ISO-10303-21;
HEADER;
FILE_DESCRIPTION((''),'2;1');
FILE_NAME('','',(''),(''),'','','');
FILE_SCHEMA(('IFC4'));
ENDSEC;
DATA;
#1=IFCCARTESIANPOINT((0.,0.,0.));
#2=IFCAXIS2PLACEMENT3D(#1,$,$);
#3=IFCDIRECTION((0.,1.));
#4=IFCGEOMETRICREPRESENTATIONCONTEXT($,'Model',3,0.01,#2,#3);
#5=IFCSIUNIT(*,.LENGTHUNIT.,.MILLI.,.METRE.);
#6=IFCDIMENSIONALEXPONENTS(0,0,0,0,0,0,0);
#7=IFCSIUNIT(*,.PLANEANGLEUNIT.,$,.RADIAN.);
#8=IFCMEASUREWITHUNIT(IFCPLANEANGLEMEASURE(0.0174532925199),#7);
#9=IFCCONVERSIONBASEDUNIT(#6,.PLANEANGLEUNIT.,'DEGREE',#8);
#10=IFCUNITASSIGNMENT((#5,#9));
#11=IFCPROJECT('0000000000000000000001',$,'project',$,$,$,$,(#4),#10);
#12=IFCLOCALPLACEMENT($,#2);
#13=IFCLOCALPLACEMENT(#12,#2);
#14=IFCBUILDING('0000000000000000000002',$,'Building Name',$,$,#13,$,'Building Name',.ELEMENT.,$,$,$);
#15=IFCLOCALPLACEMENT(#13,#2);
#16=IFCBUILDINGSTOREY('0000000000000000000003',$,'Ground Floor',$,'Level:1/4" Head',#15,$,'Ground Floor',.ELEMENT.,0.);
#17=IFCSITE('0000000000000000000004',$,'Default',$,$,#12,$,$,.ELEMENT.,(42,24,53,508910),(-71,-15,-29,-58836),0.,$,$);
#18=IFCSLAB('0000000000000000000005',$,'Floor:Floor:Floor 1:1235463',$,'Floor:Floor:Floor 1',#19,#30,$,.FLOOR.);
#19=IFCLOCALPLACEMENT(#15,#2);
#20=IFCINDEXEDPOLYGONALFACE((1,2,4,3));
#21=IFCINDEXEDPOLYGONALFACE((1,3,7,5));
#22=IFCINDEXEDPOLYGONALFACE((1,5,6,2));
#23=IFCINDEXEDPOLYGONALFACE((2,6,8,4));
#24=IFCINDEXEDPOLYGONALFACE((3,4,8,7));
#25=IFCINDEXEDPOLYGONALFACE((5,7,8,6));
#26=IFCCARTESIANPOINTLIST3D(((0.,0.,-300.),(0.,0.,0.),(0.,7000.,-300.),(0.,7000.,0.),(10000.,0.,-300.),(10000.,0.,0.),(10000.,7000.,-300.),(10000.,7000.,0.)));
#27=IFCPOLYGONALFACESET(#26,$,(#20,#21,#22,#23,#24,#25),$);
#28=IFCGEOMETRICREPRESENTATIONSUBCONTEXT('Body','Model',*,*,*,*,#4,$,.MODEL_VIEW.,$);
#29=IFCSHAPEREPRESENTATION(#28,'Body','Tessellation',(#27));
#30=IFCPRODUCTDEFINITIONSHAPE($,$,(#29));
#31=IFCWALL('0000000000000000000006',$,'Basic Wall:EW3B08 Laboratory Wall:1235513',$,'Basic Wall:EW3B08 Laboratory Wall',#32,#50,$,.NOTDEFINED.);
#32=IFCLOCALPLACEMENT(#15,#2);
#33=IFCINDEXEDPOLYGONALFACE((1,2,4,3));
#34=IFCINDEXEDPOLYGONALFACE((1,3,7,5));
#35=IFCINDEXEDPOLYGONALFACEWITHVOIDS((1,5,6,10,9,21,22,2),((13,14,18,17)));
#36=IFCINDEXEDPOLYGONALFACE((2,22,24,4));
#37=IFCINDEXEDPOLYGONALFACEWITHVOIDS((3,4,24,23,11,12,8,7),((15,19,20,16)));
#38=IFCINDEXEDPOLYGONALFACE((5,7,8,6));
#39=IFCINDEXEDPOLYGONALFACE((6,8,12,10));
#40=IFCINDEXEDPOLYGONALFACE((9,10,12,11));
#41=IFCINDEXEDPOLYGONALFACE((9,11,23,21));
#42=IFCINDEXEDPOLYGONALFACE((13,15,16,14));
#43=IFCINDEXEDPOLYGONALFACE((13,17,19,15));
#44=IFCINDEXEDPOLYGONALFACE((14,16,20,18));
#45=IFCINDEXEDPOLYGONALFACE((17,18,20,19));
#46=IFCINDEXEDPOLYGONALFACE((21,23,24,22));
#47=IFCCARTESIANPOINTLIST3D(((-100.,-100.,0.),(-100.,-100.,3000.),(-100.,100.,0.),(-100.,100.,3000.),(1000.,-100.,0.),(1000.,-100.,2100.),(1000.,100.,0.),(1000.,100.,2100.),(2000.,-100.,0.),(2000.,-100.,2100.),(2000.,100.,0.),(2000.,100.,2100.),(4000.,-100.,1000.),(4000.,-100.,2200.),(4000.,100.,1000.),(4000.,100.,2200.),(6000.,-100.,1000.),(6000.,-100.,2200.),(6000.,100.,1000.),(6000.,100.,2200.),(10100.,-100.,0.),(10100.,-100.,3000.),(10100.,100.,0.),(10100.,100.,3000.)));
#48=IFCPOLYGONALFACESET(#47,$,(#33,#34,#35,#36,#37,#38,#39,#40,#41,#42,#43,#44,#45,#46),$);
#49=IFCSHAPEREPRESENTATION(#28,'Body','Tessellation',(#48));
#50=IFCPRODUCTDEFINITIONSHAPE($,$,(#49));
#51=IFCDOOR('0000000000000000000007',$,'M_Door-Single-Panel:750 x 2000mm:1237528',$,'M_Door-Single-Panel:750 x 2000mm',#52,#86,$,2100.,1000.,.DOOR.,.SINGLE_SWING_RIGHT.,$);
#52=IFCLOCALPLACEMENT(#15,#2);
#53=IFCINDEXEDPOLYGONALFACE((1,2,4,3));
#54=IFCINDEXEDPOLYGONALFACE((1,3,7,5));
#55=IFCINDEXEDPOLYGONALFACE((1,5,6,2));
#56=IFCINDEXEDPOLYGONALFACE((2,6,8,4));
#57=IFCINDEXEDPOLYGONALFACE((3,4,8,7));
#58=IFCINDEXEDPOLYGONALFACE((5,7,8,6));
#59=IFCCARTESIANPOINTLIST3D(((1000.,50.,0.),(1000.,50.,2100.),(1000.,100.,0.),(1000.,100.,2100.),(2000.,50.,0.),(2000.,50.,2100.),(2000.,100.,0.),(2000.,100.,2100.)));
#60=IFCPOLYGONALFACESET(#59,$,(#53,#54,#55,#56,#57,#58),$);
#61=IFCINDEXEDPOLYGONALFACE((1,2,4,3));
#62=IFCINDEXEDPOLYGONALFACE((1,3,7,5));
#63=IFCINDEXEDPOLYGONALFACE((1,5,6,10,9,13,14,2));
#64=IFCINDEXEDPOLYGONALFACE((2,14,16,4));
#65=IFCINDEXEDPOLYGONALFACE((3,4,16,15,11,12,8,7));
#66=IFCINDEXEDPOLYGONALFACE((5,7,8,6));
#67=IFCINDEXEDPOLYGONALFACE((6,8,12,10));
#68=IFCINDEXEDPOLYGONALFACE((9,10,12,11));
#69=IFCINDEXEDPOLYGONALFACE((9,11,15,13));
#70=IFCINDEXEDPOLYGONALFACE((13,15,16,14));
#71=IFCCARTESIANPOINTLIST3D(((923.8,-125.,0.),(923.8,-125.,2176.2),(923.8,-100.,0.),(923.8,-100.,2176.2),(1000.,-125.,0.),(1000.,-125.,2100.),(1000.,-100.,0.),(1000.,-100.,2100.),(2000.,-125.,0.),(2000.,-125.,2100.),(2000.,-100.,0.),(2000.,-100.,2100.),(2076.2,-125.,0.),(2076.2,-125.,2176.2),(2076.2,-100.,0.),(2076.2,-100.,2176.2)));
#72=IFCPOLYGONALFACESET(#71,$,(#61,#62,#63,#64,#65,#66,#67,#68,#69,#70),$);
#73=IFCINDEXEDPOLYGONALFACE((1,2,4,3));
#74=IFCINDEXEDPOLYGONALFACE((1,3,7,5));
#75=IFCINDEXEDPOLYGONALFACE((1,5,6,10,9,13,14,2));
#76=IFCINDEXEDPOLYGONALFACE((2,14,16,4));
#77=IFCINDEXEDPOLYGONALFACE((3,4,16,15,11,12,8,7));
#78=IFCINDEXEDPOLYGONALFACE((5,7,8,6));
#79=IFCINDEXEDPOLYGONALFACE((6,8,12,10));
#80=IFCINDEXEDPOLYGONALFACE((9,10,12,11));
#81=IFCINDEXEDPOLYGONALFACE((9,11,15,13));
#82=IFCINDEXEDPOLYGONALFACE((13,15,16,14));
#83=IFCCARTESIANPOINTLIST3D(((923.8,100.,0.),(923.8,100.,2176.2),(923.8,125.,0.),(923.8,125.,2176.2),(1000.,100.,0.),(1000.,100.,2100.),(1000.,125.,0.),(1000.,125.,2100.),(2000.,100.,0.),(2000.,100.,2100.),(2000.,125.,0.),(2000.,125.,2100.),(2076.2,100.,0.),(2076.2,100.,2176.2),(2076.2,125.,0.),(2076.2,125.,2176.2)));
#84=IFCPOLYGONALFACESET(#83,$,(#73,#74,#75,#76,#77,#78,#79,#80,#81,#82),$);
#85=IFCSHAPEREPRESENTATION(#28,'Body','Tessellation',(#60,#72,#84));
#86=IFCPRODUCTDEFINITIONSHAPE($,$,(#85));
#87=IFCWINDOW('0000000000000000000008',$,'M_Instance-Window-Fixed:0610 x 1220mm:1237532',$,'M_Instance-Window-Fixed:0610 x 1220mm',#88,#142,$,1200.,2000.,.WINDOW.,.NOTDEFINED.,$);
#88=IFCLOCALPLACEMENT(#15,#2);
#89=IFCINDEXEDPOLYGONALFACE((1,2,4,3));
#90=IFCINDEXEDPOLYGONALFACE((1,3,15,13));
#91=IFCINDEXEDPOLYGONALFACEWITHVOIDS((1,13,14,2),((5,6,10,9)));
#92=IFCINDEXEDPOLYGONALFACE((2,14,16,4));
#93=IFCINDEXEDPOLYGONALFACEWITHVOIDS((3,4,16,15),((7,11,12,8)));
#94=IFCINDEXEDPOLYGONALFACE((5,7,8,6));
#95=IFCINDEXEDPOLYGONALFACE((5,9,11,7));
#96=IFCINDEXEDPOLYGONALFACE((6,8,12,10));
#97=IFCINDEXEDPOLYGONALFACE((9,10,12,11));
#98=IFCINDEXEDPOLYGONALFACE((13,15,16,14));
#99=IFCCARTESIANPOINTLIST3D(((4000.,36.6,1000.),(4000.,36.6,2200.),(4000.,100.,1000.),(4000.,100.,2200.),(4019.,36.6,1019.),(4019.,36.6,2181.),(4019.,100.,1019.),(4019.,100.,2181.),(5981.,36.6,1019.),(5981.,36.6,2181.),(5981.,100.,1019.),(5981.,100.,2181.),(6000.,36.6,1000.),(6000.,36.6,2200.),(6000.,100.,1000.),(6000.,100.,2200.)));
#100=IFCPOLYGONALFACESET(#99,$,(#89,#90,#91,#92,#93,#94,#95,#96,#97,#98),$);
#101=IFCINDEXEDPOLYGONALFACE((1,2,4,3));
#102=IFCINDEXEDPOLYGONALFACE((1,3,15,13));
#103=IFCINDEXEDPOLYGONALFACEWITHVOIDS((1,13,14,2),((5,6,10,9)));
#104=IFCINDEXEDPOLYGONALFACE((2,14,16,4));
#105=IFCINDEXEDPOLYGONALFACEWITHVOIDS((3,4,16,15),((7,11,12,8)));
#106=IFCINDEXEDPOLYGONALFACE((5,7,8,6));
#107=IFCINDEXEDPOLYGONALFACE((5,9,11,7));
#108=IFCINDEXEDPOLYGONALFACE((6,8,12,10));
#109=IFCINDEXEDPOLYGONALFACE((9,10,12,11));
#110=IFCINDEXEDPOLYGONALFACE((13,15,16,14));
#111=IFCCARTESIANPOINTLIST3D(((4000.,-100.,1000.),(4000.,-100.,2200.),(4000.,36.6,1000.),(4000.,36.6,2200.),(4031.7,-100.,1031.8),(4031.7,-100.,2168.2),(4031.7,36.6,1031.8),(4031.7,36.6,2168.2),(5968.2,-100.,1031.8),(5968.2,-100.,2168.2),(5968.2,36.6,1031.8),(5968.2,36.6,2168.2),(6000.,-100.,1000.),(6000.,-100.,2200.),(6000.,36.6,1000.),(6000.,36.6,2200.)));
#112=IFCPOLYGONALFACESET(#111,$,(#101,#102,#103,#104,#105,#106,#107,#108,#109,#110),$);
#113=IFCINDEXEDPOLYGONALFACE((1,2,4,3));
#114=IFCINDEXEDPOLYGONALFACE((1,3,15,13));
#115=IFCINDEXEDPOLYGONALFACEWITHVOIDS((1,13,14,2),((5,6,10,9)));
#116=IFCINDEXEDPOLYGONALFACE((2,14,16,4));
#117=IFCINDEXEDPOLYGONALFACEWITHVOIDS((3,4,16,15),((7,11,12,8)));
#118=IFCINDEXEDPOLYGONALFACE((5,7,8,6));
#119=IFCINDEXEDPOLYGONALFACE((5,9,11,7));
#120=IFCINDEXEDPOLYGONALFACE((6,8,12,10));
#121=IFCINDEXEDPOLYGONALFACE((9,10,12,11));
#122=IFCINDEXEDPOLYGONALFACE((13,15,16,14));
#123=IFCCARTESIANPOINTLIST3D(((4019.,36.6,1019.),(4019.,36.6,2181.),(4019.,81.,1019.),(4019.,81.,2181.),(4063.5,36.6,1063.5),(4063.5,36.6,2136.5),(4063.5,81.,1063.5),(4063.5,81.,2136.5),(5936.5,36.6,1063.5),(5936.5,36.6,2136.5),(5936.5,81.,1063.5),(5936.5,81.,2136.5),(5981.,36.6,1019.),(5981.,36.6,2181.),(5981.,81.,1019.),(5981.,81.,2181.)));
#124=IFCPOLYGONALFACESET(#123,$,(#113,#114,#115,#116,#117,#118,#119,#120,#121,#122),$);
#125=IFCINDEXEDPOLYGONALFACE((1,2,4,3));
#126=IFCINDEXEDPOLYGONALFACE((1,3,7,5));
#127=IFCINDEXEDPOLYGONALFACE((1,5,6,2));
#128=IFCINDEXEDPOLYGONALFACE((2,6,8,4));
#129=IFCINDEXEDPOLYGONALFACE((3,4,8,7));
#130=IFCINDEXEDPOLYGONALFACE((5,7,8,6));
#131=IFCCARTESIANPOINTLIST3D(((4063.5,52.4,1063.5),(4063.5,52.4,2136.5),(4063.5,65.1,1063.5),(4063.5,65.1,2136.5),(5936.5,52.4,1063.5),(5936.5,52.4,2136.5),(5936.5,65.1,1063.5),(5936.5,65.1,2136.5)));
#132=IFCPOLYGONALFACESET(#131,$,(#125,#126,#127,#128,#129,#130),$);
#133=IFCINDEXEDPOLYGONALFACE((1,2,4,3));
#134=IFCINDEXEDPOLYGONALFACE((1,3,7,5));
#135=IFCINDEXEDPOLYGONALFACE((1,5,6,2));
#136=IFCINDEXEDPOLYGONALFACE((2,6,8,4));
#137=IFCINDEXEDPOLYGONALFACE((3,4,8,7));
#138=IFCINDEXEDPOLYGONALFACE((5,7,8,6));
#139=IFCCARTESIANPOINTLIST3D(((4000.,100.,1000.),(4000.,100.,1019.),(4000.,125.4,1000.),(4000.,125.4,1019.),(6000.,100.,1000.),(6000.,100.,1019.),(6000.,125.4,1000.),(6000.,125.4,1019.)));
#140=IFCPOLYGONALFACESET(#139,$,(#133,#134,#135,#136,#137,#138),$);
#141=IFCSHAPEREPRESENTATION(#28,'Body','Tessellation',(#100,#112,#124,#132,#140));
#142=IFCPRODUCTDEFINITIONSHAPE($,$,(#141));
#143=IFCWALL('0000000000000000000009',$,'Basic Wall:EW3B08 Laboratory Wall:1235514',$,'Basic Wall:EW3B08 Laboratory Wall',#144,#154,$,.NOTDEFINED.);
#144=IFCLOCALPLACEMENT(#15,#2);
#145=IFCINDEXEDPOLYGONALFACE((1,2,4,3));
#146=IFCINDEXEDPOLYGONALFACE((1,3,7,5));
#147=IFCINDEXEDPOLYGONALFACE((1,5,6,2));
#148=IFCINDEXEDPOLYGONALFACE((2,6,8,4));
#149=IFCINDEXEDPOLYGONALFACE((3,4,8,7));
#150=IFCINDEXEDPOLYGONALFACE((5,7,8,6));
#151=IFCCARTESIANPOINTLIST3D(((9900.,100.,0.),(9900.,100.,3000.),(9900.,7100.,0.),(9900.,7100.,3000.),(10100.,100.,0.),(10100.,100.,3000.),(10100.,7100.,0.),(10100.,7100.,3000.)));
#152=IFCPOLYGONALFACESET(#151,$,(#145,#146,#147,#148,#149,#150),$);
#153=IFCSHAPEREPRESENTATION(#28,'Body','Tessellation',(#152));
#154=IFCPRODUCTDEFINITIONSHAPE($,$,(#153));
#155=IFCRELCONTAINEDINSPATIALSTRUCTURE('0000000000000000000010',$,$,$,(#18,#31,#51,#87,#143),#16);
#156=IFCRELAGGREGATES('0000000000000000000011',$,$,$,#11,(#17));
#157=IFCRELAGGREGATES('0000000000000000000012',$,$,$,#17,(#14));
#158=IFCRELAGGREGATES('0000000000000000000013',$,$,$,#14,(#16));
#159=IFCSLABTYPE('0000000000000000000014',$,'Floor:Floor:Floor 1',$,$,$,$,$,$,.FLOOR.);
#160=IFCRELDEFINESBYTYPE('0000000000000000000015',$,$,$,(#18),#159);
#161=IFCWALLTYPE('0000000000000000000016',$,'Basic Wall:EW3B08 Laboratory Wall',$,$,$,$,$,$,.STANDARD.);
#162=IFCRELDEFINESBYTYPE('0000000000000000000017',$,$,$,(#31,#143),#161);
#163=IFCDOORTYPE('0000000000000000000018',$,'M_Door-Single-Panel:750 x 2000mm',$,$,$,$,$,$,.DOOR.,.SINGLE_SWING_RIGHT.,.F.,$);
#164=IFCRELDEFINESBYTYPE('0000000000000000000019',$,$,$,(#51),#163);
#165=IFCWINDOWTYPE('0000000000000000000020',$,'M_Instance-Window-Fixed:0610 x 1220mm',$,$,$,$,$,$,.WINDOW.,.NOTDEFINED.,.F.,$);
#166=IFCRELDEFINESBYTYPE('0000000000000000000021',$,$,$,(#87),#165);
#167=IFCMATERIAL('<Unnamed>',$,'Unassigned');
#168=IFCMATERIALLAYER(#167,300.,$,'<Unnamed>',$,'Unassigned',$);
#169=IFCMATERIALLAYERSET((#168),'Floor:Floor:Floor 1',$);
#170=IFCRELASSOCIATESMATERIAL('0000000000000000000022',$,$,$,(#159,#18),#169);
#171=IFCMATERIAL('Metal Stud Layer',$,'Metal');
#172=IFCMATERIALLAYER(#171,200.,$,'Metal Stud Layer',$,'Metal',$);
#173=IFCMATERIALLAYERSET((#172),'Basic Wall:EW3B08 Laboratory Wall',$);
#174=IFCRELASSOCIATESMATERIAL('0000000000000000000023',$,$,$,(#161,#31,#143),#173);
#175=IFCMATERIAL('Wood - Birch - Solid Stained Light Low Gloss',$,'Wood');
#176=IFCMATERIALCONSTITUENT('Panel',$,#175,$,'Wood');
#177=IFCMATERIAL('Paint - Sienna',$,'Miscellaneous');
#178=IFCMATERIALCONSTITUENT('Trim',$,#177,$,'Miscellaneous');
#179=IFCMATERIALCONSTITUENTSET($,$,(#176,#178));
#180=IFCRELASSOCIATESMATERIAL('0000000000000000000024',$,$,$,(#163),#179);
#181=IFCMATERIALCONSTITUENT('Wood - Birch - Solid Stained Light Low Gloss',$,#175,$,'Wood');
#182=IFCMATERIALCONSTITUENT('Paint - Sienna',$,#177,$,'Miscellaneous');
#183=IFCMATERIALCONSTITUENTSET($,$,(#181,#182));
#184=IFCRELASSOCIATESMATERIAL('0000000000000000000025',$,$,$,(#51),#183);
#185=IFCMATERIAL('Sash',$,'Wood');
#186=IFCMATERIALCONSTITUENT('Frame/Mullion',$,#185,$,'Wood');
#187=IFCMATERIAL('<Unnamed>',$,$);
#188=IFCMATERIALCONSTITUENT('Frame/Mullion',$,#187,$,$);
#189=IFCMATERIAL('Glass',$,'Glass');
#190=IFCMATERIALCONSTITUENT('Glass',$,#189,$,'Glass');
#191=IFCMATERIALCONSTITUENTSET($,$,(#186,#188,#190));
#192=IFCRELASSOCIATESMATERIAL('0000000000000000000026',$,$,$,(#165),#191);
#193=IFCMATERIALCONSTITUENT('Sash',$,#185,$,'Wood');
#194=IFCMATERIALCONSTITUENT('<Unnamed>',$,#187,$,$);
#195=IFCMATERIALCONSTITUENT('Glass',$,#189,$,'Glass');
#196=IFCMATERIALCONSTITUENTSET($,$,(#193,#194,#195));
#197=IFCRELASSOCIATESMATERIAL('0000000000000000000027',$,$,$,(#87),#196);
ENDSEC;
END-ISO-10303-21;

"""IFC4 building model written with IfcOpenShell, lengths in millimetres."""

from ifc_helpers import new_model, entity, si_unit, converted_unit, direction, frame, frame_2d, origin, origin_2d_with_axis, place, context, subcontext, project, spatial, polyline, rectangle, outline, extrude, source, transform, mapped, material, layer, layer_set, layer_usage, constituent, constituent_set, type_object, type_shapes, element, fill, save


model = new_model("IFC4")

# Units and contexts
model_context = context("Model", 3, precision=0.01, world=origin(), true_north=direction((0.0, 1.0)))
body_context = subcontext(model_context, "Body", "Model", "MODEL_VIEW")
ifc_project = project(units=[si_unit("LENGTHUNIT", "METRE", prefix="MILLI"), converted_unit("PLANEANGLEUNIT", "DEGREE", entity("IfcPlaneAngleMeasure", 0.0174532925199), si_unit("PLANEANGLEUNIT", "RADIAN"), dimensions=[0, 0, 0, 0, 0, 0, 0])], contexts=[model_context])

# Site, building, storey
site_placement = place(None, origin())
site = spatial("IfcSite", under=ifc_project, at=site_placement, Name="Default", CompositionType="ELEMENT", RefLatitude=(42, 24, 53, 508910), RefLongitude=(-71, -15, -29, -58836), RefElevation=0.0)
building_placement = place(site_placement, origin())
building = spatial("IfcBuilding", under=site, at=building_placement, Name="Building Name", LongName="Building Name", CompositionType="ELEMENT")
storey_placement = place(building_placement, origin())
storey = spatial("IfcBuildingStorey", under=building, at=storey_placement, Name="Ground Floor", ObjectType="Level:1/4\" Head", LongName="Ground Floor", CompositionType="ELEMENT", Elevation=0.0)

# Slab
ifc_material_1 = material(Name="<Unnamed>", Category="Unassigned")
ifc_layer_1 = layer(ifc_material_1, 300.0, Name="<Unnamed>", Category="Unassigned")
ifc_layer_set_1 = layer_set([ifc_layer_1], Name="Floor:Floor:Floor 1")
ifc_layer_usage_1 = layer_usage(ifc_layer_set_1, "AXIS3", "POSITIVE", 0.0)
slab_type = type_object("IfcSlabType", Name="Floor:Floor:Floor 1", PredefinedType="FLOOR", material=ifc_layer_set_1)
slab_placement = place(storey_placement, origin())
element("IfcSlab", 1, at=slab_placement, inside=storey, type_object=slab_type, material=ifc_layer_usage_1, Name="Floor:Floor:Floor 1:1235463", ObjectType="Floor:Floor:Floor 1", PredefinedType="FLOOR", context=body_context, shape_type="SweptSolid", body=[
    extrude(rectangle(XDim=7000.0, YDim=10000.0, at=origin_2d_with_axis()), frame((5000.0, 3500.0, 0.0), z_axis=(0.0, 0.0, -1.0), x_axis=(0.0, 1.0, 0.0)), (0.0, 0.0, 1.0), 300.0),
])

# Wall, openings, door, window
ifc_material_2 = material(Name="Metal Stud Layer", Category="Metal")
ifc_layer_2 = layer(ifc_material_2, 200.0, Name="Metal Stud Layer", Category="Metal")
ifc_layer_set_2 = layer_set([ifc_layer_2], Name="Basic Wall:EW3B08 Laboratory Wall")
ifc_layer_usage_2 = layer_usage(ifc_layer_set_2, "AXIS2", "NEGATIVE", 100.0)
wall_type = type_object("IfcWallType", Name="Basic Wall:EW3B08 Laboratory Wall", PredefinedType="STANDARD", material=ifc_layer_set_2)
wall_1_placement = place(storey_placement, frame((-100.0, 0.0, 0.0)))
wall_1 = element("IfcWall", 2, at=wall_1_placement, inside=storey, type_object=wall_type, material=ifc_layer_usage_2, Name="Basic Wall:EW3B08 Laboratory Wall:1235513", ObjectType="Basic Wall:EW3B08 Laboratory Wall", PredefinedType="NOTDEFINED", context=body_context, shape_type="SweptSolid", body=[
    extrude(rectangle(XDim=10200.0, YDim=200.0, at=frame_2d((5100.0, 0.0), x_axis=(1.0, 0.0))), origin(), (0.0, 0.0, 1.0), 3000.0),
])
opening_1_placement = place(wall_1_placement, frame((1100.0, -100.0, 0.0)))
opening_1 = element("IfcOpeningElement", 3, at=opening_1_placement, cuts=wall_1, PredefinedType="OPENING", context=body_context, shape_type="SweptSolid", body=[
    extrude(rectangle(XDim=1000.0, YDim=2100.0, at=frame_2d((1050.0, 500.0), x_axis=(0.0, 1.0))), frame((0.0, 0.0, 0.0), z_axis=(0.0, 1.0, 0.0), x_axis=(0.0, 0.0, 1.0)), (0.0, 0.0, 1.0), 200.0),
])
opening_2_placement = place(wall_1_placement, frame((4100.0, -100.0, 1000.0)))
opening_2 = element("IfcOpeningElement", 4, at=opening_2_placement, cuts=wall_1, PredefinedType="OPENING", context=body_context, shape_type="SweptSolid", body=[
    extrude(rectangle(XDim=1200.0, YDim=2000.0, at=frame_2d((600.0, 1000.0), x_axis=(-1.0, 0.0))), frame((0.0, 0.0, 0.0), z_axis=(0.0, 1.0, 0.0), x_axis=(0.0, 0.0, 1.0)), (0.0, 0.0, 1.0), 200.0),
])
ifc_material_3 = material(Name="Wood - Birch - Solid Stained Light Low Gloss", Category="Wood")
ifc_constituent_1 = constituent(ifc_material_3, Name="Wood - Birch - Solid Stained Light Low Gloss", Category="Wood")
ifc_material_4 = material(Name="Paint - Sienna", Category="Miscellaneous")
ifc_constituent_2 = constituent(ifc_material_4, Name="Paint - Sienna", Category="Miscellaneous")
ifc_constituent_set_1 = constituent_set(constituents=[ifc_constituent_1, ifc_constituent_2])
ifc_constituent_3 = constituent(ifc_material_3, Name="Panel", Category="Wood")
ifc_constituent_4 = constituent(ifc_material_4, Name="Trim", Category="Miscellaneous")
ifc_constituent_set_2 = constituent_set(constituents=[ifc_constituent_3, ifc_constituent_4])
door_type = type_object("IfcDoorType", Name="M_Door-Single-Panel:750 x 2000mm", OperationType="SINGLE_SWING_RIGHT", ParameterTakesPrecedence=False, PredefinedType="DOOR", material=ifc_constituent_set_2)
shared_shape_1 = source(origin(), body_context, "Body", "SweptSolid", [
    extrude(rectangle(XDim=50.0, YDim=1000.0, at=frame_2d((0.0, 0.0), x_axis=(1.0, 0.0))), frame((500.0, 175.0, 0.0), z_axis=(0.0, 0.0, 1.0), x_axis=(0.0, 1.0, 0.0)), (0.0, 0.0, 1.0), 2100.0),
    extrude(outline(polyline([(-1107.2, -576.2), (1069.0, -576.2), (1069.0, -500.0), (-1031.0, -500.0), (-1031.0, 500.0), (1069.0, 500.0), (1069.0, 576.2), (-1107.2, 576.2), (-1107.2, -576.2)])), frame((500.0, -25.0, 1069.0), z_axis=(0.0, 1.0, 0.0), x_axis=(0.0, 0.0, -1.0)), (0.0, 0.0, 1.0), 25.0),
    extrude(outline(polyline([(-576.2, -1107.2), (576.2, -1107.2), (576.2, 1069.0), (500.0, 1069.0), (500.0, -1031.0), (-500.0, -1031.0), (-500.0, 1069.0), (-576.2, 1069.0), (-576.2, -1107.2)])), frame((500.0, 200.0, 1069.0), z_axis=(0.0, 1.0, 0.0), x_axis=(1.0, 0.0, 0.0)), (0.0, 0.0, 1.0), 25.0),
])
type_shapes(door_type, [shared_shape_1])
door_1_placement = place(opening_1_placement, origin())
door_1 = element("IfcDoor", 5, at=door_1_placement, inside=storey, type_object=door_type, material=ifc_constituent_set_1, Name="M_Door-Single-Panel:750 x 2000mm:1237528", ObjectType="M_Door-Single-Panel:750 x 2000mm", OperationType="SINGLE_SWING_RIGHT", OverallHeight=2100.0, OverallWidth=1000.0, PredefinedType="DOOR", context=body_context, shape_type="MappedRepresentation", body=[
    mapped(shared_shape_1, transform((0.0, 0.0, 0.0), scale=1.0)),
])
fill(opening_1, door_1)
ifc_material_5 = material(Name="Sash", Category="Wood")
ifc_constituent_5 = constituent(ifc_material_5, Name="Sash", Category="Wood")
ifc_material_6 = material(Name="<Unnamed>")
ifc_constituent_6 = constituent(ifc_material_6, Name="<Unnamed>")
ifc_material_7 = material(Name="Glass", Category="Glass")
ifc_constituent_7 = constituent(ifc_material_7, Name="Glass", Category="Glass")
ifc_constituent_set_3 = constituent_set(constituents=[ifc_constituent_5, ifc_constituent_6, ifc_constituent_7])
ifc_constituent_8 = constituent(ifc_material_5, Name="Frame/Mullion", Category="Wood")
ifc_constituent_9 = constituent(ifc_material_6, Name="Frame/Mullion")
ifc_constituent_10 = constituent(ifc_material_7, Name="Glass", Category="Glass")
ifc_constituent_set_4 = constituent_set(constituents=[ifc_constituent_8, ifc_constituent_9, ifc_constituent_10])
window_type = type_object("IfcWindowType", Name="M_Instance-Window-Fixed:0610 x 1220mm", ParameterTakesPrecedence=False, PartitioningType="NOTDEFINED", PredefinedType="WINDOW", material=ifc_constituent_set_4)
shared_shape_2 = source(origin(), body_context, "Body", "SweptSolid", [
    extrude(outline(polyline([(-600.0, -1000.0), (600.0, -1000.0), (600.0, 1000.0), (-600.0, 1000.0), (-600.0, -1000.0)]), holes=[polyline([(-581.0, -981.0), (-581.0, 981.0), (581.0, 981.0), (581.0, -981.0), (-581.0, -981.0)])]), frame((1000.0, 136.6, 600.0), z_axis=(0.0, 1.0, 0.0), x_axis=(0.0, 0.0, -1.0)), (0.0, 0.0, 1.0), 63.5),
    extrude(outline(polyline([(-1000.0, -600.0), (1000.0, -600.0), (1000.0, 600.0), (-1000.0, 600.0), (-1000.0, -600.0)]), holes=[polyline([(-968.2, -568.2), (-968.2, 568.2), (968.2, 568.2), (968.2, -568.2), (-968.2, -568.2)])]), frame((1000.0, 0.0, 600.0), z_axis=(0.0, 1.0, 0.0), x_axis=(1.0, 0.0, 0.0)), (0.0, 0.0, 1.0), 136.6),
    extrude(outline(polyline([(-981.0, -581.0), (981.0, -581.0), (981.0, 581.0), (-981.0, 581.0), (-981.0, -581.0)]), holes=[polyline([(-936.5, -536.5), (-936.5, 536.5), (936.5, 536.5), (936.5, -536.5), (-936.5, -536.5)])]), frame((1000.0, 136.6, 600.0), z_axis=(0.0, 1.0, 0.0), x_axis=(1.0, 0.0, 0.0)), (0.0, 0.0, 1.0), 44.5),
    extrude(rectangle(XDim=12.7, YDim=1873.0, at=frame_2d((0.0, 0.0), x_axis=(1.0, 0.0))), frame((1000.0, 158.8, 63.5), z_axis=(0.0, 0.0, 1.0), x_axis=(0.0, 1.0, 0.0)), (0.0, 0.0, 1.0), 1073.0),
    extrude(rectangle(XDim=25.4, YDim=2000.0, at=frame_2d((0.0, 0.0), x_axis=(1.0, 0.0))), frame((1000.0, 212.7, 0.0), z_axis=(0.0, 0.0, 1.0), x_axis=(0.0, -1.0, 0.0)), (0.0, 0.0, 1.0), 19.1),
])
type_shapes(window_type, [shared_shape_2])
window_1_placement = place(opening_2_placement, origin())
window_1 = element("IfcWindow", 6, at=window_1_placement, inside=storey, type_object=window_type, material=ifc_constituent_set_3, Name="M_Instance-Window-Fixed:0610 x 1220mm:1237532", ObjectType="M_Instance-Window-Fixed:0610 x 1220mm", OverallHeight=1200.0, OverallWidth=2000.0, PartitioningType="NOTDEFINED", PredefinedType="WINDOW", context=body_context, shape_type="MappedRepresentation", body=[
    mapped(shared_shape_2, transform((0.0, 0.0, 0.0), scale=1.0)),
])
fill(opening_2, window_1)

# Wall
ifc_layer_usage_3 = layer_usage(ifc_layer_set_2, "AXIS2", "NEGATIVE", 100.0)
wall_2_placement = place(storey_placement, frame((10000.0, 100.0, 0.0), z_axis=(0.0, 0.0, 1.0), x_axis=(0.0, 1.0, 0.0)))
element("IfcWall", 7, at=wall_2_placement, inside=storey, type_object=wall_type, material=ifc_layer_usage_3, Name="Basic Wall:EW3B08 Laboratory Wall:1235514", ObjectType="Basic Wall:EW3B08 Laboratory Wall", PredefinedType="NOTDEFINED", context=body_context, shape_type="SweptSolid", body=[
    extrude(rectangle(XDim=7000.0, YDim=200.0, at=frame_2d((3500.0, 0.0), x_axis=(-1.0, 0.0))), origin(), (0.0, 0.0, 1.0), 3000.0),
])

save(model, "model.ifc")
